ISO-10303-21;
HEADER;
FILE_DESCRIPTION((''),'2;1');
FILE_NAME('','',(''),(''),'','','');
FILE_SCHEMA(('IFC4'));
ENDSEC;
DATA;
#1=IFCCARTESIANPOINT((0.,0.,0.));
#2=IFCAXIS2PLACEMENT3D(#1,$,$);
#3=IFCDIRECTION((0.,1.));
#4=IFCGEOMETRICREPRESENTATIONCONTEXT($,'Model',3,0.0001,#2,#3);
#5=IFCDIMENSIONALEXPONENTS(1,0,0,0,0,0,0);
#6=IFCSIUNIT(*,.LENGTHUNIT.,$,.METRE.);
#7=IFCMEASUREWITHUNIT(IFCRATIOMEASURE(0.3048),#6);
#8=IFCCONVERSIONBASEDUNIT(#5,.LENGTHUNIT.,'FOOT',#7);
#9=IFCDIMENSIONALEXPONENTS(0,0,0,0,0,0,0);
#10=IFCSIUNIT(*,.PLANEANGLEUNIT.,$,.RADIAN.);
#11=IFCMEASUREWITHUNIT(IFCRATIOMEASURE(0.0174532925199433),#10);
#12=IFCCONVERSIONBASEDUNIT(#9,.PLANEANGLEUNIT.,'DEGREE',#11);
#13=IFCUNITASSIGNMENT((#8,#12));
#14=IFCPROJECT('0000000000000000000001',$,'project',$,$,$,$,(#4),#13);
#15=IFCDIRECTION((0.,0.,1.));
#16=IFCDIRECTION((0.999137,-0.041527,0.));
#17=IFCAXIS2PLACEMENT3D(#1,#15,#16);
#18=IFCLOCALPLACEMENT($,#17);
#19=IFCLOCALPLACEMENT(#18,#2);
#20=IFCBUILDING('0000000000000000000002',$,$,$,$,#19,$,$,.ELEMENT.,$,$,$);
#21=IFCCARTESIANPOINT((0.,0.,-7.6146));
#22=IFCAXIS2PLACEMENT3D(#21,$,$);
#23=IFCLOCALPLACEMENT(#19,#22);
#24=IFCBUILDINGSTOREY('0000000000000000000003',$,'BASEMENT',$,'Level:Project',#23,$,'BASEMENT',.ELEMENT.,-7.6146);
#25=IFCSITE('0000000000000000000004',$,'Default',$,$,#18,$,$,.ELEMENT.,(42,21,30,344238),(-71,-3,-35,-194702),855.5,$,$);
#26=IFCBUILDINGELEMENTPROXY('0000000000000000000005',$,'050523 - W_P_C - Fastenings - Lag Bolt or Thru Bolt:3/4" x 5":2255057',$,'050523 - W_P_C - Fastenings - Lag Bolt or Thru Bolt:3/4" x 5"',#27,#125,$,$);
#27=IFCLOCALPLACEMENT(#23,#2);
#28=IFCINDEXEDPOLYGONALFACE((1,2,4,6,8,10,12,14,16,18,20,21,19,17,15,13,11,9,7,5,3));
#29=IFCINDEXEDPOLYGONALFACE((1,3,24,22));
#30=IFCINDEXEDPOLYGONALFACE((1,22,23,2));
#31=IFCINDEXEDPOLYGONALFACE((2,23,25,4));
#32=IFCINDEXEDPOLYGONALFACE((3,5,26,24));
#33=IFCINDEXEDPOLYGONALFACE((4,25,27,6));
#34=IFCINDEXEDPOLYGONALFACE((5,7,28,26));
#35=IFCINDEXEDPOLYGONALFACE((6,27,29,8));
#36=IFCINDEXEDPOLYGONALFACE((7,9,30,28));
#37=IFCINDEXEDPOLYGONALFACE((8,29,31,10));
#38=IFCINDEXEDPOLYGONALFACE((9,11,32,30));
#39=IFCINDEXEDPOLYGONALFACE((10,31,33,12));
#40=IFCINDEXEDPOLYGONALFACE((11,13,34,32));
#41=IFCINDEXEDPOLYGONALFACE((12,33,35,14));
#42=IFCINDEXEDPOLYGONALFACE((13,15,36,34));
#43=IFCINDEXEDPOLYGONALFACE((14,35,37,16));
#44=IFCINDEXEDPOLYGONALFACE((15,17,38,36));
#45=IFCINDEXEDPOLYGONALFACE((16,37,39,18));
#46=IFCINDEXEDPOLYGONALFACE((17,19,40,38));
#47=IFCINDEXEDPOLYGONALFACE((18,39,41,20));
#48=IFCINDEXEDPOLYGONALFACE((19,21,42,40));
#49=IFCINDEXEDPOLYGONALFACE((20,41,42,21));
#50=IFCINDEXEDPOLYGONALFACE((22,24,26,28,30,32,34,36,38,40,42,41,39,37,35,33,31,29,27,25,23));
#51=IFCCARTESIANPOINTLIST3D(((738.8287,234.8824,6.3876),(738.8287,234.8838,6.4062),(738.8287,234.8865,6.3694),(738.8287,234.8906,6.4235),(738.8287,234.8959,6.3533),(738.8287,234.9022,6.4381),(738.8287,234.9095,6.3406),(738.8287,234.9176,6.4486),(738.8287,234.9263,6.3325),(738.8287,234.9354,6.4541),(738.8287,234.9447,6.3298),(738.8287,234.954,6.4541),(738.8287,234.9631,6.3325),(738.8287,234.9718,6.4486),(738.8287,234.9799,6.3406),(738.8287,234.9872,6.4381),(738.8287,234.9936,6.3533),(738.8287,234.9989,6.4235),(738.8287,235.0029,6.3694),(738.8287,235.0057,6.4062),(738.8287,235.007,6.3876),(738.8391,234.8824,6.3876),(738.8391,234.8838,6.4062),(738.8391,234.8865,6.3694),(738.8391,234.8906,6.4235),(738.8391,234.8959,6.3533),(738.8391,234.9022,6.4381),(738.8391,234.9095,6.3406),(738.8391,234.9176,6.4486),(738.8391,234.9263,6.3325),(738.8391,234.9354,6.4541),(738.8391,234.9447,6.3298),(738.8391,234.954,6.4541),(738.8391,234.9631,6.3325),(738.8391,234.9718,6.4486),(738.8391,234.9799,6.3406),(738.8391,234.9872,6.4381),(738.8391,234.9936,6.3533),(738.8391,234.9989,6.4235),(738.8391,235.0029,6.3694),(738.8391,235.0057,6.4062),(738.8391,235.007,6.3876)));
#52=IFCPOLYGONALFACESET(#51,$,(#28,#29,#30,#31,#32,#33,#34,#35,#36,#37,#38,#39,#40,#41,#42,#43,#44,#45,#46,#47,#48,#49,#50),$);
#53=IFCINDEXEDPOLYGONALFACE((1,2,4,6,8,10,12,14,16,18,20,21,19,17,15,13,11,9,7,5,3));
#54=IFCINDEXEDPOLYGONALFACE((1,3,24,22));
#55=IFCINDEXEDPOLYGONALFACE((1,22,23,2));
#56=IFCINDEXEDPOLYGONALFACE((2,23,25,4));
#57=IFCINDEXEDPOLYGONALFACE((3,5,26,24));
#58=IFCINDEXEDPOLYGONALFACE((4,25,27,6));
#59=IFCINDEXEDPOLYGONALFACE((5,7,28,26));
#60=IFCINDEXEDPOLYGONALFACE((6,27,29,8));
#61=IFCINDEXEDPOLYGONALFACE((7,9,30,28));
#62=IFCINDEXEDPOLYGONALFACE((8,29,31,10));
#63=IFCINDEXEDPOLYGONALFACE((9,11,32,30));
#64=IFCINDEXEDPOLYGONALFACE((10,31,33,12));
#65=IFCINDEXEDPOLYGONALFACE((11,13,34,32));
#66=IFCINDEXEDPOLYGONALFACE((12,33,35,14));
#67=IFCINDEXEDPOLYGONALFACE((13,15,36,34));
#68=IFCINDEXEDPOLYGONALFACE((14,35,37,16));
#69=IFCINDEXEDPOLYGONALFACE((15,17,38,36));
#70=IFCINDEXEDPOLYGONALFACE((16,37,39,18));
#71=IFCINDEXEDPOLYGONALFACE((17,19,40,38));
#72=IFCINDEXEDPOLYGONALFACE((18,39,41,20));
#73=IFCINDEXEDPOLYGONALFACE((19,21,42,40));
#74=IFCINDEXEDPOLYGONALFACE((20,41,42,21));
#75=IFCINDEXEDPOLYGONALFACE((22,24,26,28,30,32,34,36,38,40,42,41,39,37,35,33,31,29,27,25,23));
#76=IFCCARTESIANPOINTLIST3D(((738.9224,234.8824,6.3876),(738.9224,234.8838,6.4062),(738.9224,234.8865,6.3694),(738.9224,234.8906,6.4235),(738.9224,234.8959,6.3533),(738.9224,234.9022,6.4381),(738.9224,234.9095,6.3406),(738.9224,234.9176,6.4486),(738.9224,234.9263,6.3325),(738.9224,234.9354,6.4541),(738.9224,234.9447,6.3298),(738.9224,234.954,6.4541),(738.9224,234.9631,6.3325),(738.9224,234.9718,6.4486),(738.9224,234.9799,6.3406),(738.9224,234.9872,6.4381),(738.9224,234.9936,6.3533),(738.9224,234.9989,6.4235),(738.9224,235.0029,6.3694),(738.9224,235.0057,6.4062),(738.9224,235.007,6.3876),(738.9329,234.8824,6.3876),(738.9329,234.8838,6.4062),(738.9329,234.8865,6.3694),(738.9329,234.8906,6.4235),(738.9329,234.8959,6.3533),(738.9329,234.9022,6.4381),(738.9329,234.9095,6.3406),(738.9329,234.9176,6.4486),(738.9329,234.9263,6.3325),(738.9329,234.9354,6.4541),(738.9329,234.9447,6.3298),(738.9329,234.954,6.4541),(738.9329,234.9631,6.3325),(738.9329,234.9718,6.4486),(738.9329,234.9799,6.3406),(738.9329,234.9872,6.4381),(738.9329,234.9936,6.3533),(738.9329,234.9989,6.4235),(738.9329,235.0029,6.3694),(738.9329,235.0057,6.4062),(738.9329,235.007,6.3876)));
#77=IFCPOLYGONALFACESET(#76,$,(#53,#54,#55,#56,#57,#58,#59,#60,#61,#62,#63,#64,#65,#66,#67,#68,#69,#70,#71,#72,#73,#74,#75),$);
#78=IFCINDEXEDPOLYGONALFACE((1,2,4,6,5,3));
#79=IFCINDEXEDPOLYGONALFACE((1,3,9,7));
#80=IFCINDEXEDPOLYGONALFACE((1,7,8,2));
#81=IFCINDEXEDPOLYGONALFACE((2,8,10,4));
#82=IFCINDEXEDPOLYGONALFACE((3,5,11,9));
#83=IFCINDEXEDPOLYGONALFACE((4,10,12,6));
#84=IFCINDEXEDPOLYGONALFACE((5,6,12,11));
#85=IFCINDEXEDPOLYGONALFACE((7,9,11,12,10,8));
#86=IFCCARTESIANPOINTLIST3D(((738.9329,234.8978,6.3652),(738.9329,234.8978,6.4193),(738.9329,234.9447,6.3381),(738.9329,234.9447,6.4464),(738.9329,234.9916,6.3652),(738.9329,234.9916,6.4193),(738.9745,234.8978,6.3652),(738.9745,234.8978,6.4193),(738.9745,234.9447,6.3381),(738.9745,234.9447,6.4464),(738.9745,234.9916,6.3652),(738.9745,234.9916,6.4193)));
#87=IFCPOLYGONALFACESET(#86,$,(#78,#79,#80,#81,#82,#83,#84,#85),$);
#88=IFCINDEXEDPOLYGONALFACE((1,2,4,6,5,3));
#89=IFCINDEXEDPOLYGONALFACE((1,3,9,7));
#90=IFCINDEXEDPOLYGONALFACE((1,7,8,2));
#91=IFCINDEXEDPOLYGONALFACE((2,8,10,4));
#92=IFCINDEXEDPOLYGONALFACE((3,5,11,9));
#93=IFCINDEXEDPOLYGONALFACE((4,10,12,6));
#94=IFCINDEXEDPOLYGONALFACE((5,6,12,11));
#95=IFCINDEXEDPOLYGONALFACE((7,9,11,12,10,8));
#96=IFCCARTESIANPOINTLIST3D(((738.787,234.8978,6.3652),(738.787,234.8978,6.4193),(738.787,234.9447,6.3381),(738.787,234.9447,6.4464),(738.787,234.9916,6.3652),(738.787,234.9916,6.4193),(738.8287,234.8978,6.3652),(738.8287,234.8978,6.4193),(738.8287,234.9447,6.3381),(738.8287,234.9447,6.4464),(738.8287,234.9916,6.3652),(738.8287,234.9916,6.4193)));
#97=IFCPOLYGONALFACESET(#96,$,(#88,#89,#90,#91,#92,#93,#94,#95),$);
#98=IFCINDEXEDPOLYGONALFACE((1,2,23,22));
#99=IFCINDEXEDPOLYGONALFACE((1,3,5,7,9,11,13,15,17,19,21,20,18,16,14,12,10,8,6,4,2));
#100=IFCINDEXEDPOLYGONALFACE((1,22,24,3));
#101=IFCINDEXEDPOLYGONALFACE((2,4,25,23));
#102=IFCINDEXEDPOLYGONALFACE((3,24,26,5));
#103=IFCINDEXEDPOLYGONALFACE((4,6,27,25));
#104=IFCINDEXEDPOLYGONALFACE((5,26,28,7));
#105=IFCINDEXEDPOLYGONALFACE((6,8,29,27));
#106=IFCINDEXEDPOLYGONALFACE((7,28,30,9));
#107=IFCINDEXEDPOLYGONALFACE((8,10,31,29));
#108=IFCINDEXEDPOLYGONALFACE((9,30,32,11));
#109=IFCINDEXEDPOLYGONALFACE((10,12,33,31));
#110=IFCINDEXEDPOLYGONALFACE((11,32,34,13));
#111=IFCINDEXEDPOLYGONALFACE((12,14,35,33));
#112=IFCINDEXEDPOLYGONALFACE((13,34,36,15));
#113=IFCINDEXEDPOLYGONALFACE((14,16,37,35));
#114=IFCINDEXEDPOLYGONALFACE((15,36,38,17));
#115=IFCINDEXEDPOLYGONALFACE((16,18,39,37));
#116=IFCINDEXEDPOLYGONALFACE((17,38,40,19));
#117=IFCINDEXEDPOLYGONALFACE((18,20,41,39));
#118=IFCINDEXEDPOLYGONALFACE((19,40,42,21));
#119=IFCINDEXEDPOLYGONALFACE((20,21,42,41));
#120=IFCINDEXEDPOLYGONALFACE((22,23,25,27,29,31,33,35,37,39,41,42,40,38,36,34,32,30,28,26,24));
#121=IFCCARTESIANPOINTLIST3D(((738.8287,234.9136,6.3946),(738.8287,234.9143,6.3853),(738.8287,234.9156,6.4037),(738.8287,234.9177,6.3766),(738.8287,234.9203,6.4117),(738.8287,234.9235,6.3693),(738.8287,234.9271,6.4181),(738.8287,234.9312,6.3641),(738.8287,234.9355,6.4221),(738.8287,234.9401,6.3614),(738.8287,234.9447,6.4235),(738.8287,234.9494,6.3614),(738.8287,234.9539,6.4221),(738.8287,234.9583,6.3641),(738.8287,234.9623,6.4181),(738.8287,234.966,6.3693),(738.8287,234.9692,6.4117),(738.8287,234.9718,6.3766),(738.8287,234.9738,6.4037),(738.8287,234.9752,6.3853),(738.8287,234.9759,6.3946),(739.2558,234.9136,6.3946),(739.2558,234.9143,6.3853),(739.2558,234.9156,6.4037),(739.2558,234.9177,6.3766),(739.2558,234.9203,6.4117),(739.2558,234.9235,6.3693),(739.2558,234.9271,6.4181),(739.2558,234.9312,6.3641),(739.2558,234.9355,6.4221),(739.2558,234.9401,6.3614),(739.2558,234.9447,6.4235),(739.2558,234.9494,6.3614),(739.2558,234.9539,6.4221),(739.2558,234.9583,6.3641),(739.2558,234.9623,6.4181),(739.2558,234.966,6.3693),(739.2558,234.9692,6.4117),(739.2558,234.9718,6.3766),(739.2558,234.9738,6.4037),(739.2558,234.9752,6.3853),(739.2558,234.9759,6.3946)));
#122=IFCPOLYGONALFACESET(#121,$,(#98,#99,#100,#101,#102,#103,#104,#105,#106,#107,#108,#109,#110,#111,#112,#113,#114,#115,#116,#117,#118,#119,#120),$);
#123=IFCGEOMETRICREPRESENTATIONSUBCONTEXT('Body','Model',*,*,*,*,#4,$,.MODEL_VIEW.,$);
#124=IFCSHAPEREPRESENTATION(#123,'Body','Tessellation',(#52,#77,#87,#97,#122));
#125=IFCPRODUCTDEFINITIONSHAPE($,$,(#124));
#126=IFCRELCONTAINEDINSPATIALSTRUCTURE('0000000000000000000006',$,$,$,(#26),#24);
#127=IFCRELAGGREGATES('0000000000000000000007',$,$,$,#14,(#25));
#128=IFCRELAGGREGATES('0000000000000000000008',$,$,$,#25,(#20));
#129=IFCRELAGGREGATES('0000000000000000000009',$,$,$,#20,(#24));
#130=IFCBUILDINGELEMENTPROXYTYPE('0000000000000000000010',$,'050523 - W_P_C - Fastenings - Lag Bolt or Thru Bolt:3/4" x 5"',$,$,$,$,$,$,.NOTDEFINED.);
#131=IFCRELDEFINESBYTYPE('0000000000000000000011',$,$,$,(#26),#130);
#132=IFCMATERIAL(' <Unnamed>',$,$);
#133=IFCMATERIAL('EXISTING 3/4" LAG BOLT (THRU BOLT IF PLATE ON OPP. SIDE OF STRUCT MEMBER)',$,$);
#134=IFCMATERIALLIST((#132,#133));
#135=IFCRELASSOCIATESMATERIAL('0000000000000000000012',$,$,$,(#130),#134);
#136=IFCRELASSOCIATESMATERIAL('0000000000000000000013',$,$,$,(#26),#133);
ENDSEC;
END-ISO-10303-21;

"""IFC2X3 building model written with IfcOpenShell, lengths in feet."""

from ifc_helpers import new_model, entity, si_unit, converted_unit, direction, frame, frame_2d, origin, place, context, subcontext, project, spatial, polyline, circle, outline, extrude, source, transform, mapped, material, material_list, type_object, type_shapes, element, save


model = new_model("IFC2X3")

# Units and contexts
model_context = context("Model", 3, precision=0.0001, world=origin(), true_north=direction((0.0, 1.0)))
body_context = subcontext(model_context, "Body", "Model", "MODEL_VIEW")
ifc_project = project(units=[converted_unit("LENGTHUNIT", "FOOT", entity("IfcRatioMeasure", 0.3048), si_unit("LENGTHUNIT", "METRE"), dimensions=[1, 0, 0, 0, 0, 0, 0]), converted_unit("PLANEANGLEUNIT", "DEGREE", entity("IfcRatioMeasure", 0.0174532925199433), si_unit("PLANEANGLEUNIT", "RADIAN"), dimensions=[0, 0, 0, 0, 0, 0, 0])], contexts=[model_context])

# Site, building, storey
site_placement = place(None, frame((0.0, 0.0, 0.0), z_axis=(0.0, 0.0, 1.0), x_axis=(0.999137, -0.041527, 0.0)))
site = spatial("IfcSite", under=ifc_project, at=site_placement, Name="Default", CompositionType="ELEMENT", RefLatitude=(42, 21, 30, 344238), RefLongitude=(-71, -3, -35, -194702), RefElevation=855.5)
building_placement = place(site_placement, origin())
building = spatial("IfcBuilding", under=site, at=building_placement, CompositionType="ELEMENT")
storey_placement = place(building_placement, frame((0.0, 0.0, -7.6146)))
storey = spatial("IfcBuildingStorey", under=building, at=storey_placement, Name="BASEMENT", ObjectType="Level:Project", LongName="BASEMENT", CompositionType="ELEMENT", Elevation=-7.6146)

# Building element proxy
ifc_material_1 = material(Name="EXISTING 3/4\" LAG BOLT (THRU BOLT IF PLATE ON OPP. SIDE OF STRUCT MEMBER)")
ifc_material_2 = material(Name=" <Unnamed>")
ifc_material_list_1 = material_list([ifc_material_2, ifc_material_1])
building_element_proxy_type_1 = type_object("IfcBuildingElementProxyType", Name="050523 - W_P_C - Fastenings - Lag Bolt or Thru Bolt:3/4\" x 5\"", PredefinedType="NOTDEFINED", material=ifc_material_list_1)
shared_shape_1 = source(origin(), body_context, "Body", "SweptSolid", [
    extrude(circle(Radius=0.0625, at=frame_2d((0.0, 0.0), x_axis=(1.0, 0.0))), frame((0.0, 0.0, 0.0), z_axis=(0.0, 0.0, 1.0), x_axis=(0.0, -1.0, 0.0)), (0.0, 0.0, 1.0), 0.0104),
    extrude(circle(Radius=0.0625, at=frame_2d((0.0, 0.0), x_axis=(1.0, 0.0))), frame((0.0, 0.0, -0.0938), z_axis=(0.0, 0.0, 1.0), x_axis=(0.0, -1.0, 0.0)), (0.0, 0.0, 1.0), 0.0104),
    extrude(outline(polyline([(-0.0271, -0.0469), (0.0271, -0.0469), (0.0541, 0.0), (0.0271, 0.0469), (-0.0271, 0.0469), (-0.0541, 0.0), (-0.0271, -0.0469)])), frame((0.0, 0.0, -0.1354), z_axis=(0.0, 0.0, 1.0), x_axis=(0.866025, -0.5, 0.0)), (0.0, 0.0, 1.0), 0.0417),
    extrude(outline(polyline([(-0.0271, -0.0469), (0.0271, -0.0469), (0.0541, 0.0), (0.0271, 0.0469), (-0.0271, 0.0469), (-0.0541, 0.0), (-0.0271, -0.0469)])), frame((0.0, 0.0, 0.0104), z_axis=(0.0, 0.0, 1.0), x_axis=(0.0, -1.0, 0.0)), (0.0, 0.0, 1.0), 0.0417),
    extrude(circle(Radius=0.0312, at=frame_2d((0.0, 0.0), x_axis=(1.0, 0.0))), frame((0.0, 0.0, -0.4167), z_axis=(0.0, 0.0, 1.0), x_axis=(0.0, 1.0, 0.0)), (0.0, 0.0, 1.0), 0.4271),
])
type_shapes(building_element_proxy_type_1, [shared_shape_1])
for number, where, z_axis, x_axis, name in (
    (1, (738.8391, 234.9447, 6.3923), (-1.0, 0.0, 0.0), (0.0, -1.0, 0.0), "050523 - W_P_C - Fastenings - Lag Bolt or Thru Bolt:3/4\" x 5\":2255057"),
):
    element("IfcBuildingElementProxy", number, at=place(storey_placement, frame(where, z_axis=z_axis, x_axis=x_axis)), inside=storey, type_object=building_element_proxy_type_1, material=ifc_material_1, Name=name, ObjectType="050523 - W_P_C - Fastenings - Lag Bolt or Thru Bolt:3/4\" x 5\"", context=body_context, shape_type="MappedRepresentation", body=[
        mapped(shared_shape_1, transform((0.0, 0.0, 0.0), scale=1.0)),
    ])

save(model, "model.ifc")
